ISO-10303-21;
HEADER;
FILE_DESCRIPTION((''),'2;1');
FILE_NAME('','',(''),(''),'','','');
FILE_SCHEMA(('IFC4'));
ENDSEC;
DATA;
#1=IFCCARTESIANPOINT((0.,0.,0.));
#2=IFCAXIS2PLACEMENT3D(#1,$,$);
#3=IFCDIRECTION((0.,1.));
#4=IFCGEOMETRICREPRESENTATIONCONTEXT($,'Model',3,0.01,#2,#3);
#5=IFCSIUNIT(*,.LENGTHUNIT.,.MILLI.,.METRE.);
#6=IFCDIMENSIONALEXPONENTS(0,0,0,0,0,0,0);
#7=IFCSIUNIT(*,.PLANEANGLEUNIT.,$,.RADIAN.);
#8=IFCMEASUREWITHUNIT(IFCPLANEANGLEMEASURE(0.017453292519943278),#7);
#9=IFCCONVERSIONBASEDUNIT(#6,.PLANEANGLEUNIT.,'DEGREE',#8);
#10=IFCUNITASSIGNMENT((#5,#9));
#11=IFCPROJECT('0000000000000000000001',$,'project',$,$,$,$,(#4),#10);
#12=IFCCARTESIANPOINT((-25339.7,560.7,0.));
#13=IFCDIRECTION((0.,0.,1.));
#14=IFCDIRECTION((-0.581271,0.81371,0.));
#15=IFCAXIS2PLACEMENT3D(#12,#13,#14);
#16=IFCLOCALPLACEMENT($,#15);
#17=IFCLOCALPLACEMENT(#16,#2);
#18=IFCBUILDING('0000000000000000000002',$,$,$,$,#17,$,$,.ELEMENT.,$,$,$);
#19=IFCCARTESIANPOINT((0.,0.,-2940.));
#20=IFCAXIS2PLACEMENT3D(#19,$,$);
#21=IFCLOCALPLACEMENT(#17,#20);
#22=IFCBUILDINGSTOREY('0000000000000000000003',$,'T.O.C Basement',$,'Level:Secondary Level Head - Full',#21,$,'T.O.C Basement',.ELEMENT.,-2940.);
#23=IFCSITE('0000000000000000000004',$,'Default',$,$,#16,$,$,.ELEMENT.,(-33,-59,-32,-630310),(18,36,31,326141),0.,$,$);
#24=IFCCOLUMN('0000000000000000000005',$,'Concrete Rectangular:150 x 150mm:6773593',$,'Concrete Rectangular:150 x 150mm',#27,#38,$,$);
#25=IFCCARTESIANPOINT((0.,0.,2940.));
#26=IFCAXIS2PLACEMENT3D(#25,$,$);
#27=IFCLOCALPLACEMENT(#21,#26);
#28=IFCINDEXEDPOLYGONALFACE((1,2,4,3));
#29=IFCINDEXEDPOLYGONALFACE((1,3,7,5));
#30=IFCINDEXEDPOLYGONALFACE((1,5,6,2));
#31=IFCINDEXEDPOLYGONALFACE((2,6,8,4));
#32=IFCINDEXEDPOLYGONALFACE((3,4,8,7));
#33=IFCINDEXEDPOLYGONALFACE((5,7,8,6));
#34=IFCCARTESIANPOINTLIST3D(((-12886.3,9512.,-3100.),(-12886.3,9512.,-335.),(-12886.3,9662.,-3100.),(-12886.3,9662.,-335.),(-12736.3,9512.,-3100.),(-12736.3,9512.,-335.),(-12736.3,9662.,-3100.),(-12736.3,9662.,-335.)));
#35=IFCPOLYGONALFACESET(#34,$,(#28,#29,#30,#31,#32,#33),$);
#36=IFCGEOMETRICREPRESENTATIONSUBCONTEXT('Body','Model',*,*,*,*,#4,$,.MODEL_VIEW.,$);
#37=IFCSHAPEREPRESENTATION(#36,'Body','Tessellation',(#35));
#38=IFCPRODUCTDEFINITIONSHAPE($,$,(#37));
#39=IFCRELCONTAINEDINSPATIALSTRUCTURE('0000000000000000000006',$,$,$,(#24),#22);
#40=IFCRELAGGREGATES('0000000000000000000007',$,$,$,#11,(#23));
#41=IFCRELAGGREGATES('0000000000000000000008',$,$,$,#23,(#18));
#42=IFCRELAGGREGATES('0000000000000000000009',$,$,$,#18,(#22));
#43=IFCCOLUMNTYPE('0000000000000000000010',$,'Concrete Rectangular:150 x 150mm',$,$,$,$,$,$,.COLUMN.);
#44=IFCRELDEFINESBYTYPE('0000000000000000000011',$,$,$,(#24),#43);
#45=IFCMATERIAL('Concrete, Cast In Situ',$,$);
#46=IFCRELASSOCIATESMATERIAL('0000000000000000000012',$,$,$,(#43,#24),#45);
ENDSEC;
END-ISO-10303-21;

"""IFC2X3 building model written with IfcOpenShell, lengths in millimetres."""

from ifc_helpers import new_model, entity, si_unit, converted_unit, direction, frame, frame_2d, origin, place, context, subcontext, project, spatial, rectangle, extrude, source, transform, mapped, material, type_object, type_shapes, element, save


model = new_model("IFC2X3")

# Units and contexts
model_context = context("Model", 3, precision=0.01, world=origin(), true_north=direction((0.0, 1.0)))
body_context = subcontext(model_context, "Body", "Model", "MODEL_VIEW")
ifc_project = project(units=[si_unit("LENGTHUNIT", "METRE", prefix="MILLI"), converted_unit("PLANEANGLEUNIT", "DEGREE", entity("IfcPlaneAngleMeasure", 0.017453292519943278), si_unit("PLANEANGLEUNIT", "RADIAN"), dimensions=[0, 0, 0, 0, 0, 0, 0])], contexts=[model_context])

# Site, building, storey
site_placement = place(None, frame((-25339.7, 560.7, 0.0), z_axis=(0.0, 0.0, 1.0), x_axis=(-0.581271, 0.81371, 0.0)))
site = spatial("IfcSite", under=ifc_project, at=site_placement, Name="Default", CompositionType="ELEMENT", RefLatitude=(-33, -59, -32, -630310), RefLongitude=(18, 36, 31, 326141), RefElevation=0.0)
building_placement = place(site_placement, origin())
building = spatial("IfcBuilding", under=site, at=building_placement, CompositionType="ELEMENT")
storey_placement = place(building_placement, frame((0.0, 0.0, -2940.0)))
storey = spatial("IfcBuildingStorey", under=building, at=storey_placement, Name="T.O.C Basement", ObjectType="Level:Secondary Level Head - Full", LongName="T.O.C Basement", CompositionType="ELEMENT", Elevation=-2940.0)

# Shared definitions
ifc_material_1 = material(Name="Concrete, Cast In Situ")

# Column
column_type = type_object("IfcColumnType", Name="Concrete Rectangular:150 x 150mm", PredefinedType="COLUMN", material=ifc_material_1)
shared_shape = source(origin(), body_context, "Body", "SweptSolid", [
    extrude(rectangle(XDim=150.0, YDim=150.0, at=frame_2d((0.0, 0.0), x_axis=(1.0, 0.0))), frame((-12811.3, 9587.0, -3100.0), z_axis=(0.0, 0.0, 1.0), x_axis=(-1.0, 0.0, 0.0)), (0.0, 0.0, 1.0), 2765.0),
])
type_shapes(column_type, [shared_shape])
column_placement = place(storey_placement, frame((0.0, 0.0, 2940.0)))
element("IfcColumn", 1, at=column_placement, inside=storey, type_object=column_type, material=ifc_material_1, Name="Concrete Rectangular:150 x 150mm:6773593", ObjectType="Concrete Rectangular:150 x 150mm", context=body_context, shape_type="MappedRepresentation", body=[
    mapped(shared_shape, transform((0.0, 0.0, 0.0), scale=1.0)),
])

save(model, "model.ifc")
